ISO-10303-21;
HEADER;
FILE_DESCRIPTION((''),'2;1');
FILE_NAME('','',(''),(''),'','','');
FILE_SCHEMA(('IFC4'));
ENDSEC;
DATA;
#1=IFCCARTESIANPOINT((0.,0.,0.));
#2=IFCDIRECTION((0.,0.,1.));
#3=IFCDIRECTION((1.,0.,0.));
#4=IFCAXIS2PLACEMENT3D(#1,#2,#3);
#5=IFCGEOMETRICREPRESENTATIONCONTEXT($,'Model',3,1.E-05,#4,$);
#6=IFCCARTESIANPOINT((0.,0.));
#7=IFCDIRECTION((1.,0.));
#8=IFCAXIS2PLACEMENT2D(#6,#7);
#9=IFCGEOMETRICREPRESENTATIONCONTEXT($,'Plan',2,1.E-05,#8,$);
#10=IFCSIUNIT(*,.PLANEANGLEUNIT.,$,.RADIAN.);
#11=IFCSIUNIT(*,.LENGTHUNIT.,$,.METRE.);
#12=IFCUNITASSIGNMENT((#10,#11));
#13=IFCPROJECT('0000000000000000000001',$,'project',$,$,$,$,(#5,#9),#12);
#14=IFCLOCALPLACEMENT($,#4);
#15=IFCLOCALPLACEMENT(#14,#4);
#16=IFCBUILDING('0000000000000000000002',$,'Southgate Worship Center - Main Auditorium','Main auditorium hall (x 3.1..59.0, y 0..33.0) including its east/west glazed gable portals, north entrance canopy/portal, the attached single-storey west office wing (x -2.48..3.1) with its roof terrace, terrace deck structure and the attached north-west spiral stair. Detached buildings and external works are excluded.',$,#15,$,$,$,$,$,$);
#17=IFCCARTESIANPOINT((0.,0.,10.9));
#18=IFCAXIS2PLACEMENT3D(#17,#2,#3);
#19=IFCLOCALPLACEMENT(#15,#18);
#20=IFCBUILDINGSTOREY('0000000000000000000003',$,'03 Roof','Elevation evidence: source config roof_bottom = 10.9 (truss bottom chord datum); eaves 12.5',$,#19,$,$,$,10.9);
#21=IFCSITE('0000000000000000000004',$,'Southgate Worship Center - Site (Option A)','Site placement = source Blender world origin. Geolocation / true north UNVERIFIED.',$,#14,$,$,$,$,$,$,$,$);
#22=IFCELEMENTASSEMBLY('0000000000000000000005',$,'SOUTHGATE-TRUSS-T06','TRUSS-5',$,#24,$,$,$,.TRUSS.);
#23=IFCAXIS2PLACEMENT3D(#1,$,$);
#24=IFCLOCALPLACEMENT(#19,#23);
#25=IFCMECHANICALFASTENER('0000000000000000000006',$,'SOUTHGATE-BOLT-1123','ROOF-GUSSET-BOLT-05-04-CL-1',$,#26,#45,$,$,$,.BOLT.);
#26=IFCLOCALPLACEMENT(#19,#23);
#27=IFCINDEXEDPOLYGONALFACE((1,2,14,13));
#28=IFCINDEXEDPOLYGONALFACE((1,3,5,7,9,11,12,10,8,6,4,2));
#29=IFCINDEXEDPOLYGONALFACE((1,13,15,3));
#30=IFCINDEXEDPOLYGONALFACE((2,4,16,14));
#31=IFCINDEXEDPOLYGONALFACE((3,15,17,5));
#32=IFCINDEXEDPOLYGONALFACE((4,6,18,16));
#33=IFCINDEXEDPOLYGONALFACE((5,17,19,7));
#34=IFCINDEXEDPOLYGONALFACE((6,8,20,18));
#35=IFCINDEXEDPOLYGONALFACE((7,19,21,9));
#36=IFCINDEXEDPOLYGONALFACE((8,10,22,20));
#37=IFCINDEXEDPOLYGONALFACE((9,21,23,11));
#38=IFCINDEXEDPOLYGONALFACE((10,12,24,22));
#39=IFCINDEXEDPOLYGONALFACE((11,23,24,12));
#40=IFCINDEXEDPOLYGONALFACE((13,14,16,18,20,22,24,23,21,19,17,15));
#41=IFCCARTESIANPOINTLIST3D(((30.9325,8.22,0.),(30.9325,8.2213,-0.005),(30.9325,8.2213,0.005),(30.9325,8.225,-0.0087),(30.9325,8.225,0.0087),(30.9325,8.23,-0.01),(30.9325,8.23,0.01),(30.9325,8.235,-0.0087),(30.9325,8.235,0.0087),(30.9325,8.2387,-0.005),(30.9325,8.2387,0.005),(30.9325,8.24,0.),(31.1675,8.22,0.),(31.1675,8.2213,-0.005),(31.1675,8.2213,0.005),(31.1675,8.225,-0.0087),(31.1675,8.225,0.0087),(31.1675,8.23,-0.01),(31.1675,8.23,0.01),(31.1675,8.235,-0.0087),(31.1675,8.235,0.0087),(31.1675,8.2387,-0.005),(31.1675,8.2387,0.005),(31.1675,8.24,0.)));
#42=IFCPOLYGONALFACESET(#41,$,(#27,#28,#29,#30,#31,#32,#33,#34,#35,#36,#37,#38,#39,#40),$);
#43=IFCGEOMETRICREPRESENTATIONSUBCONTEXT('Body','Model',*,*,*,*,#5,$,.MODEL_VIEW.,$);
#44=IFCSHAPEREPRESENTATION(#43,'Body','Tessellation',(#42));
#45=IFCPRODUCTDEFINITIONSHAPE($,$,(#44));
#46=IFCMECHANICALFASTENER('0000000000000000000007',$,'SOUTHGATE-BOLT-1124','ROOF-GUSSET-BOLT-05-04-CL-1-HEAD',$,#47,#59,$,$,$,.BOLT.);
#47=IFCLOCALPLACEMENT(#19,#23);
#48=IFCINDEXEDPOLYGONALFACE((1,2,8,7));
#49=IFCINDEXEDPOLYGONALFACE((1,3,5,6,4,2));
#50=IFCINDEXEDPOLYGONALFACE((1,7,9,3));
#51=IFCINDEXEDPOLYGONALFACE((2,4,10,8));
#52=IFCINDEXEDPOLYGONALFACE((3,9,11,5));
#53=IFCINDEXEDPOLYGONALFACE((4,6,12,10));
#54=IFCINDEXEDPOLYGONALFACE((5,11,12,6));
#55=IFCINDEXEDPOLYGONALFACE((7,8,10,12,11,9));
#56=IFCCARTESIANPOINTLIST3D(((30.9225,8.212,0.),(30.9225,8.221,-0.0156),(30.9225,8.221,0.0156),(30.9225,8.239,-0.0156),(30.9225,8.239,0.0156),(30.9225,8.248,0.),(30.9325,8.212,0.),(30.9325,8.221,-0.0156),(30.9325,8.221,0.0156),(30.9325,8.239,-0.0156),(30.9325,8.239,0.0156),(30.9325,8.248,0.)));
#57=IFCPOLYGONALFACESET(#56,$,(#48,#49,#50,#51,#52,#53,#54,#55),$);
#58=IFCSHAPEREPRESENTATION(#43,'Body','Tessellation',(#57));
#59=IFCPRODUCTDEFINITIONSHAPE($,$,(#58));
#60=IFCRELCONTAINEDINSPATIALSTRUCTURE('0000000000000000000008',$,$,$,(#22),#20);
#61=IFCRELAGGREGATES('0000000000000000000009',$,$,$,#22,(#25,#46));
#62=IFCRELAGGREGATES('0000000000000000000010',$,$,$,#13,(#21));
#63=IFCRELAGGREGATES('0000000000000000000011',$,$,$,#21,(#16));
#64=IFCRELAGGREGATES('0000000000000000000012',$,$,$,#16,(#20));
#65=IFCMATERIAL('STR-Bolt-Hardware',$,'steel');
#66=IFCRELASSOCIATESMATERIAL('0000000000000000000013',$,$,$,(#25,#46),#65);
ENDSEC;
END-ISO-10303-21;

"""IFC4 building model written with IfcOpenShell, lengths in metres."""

from ifc_helpers import new_model, si_unit, frame, origin_with_axes, origin_2d_with_axis, place, context, subcontext, project, spatial, indexed_curve, outline, extrude, material, element, aggregate, save


model = new_model("IFC4")

# Units and contexts
model_context = context("Model", 3, precision=1e-05, world=origin_with_axes())
plan_context = context("Plan", 2, precision=1e-05, world=origin_2d_with_axis())
body_context = subcontext(model_context, "Body", "Model", "MODEL_VIEW")
ifc_project = project(units=[si_unit("PLANEANGLEUNIT", "RADIAN"), si_unit("LENGTHUNIT", "METRE")], contexts=[model_context, plan_context])

# Site, building, storey
site_placement = place(None, origin_with_axes())
site = spatial("IfcSite", under=ifc_project, at=site_placement, Name="Southgate Worship Center - Site (Option A)", Description="Site placement = source Blender world origin. Geolocation / true north UNVERIFIED.")
building_placement = place(site_placement, origin_with_axes())
building = spatial("IfcBuilding", under=site, at=building_placement, Name="Southgate Worship Center - Main Auditorium", Description="Main auditorium hall (x 3.1..59.0, y 0..33.0) including its east/west glazed gable portals, north entrance canopy/portal, the attached single-storey west office wing (x -2.48..3.1) with its roof terrace, terrace deck structure and the attached north-west spiral stair. Detached buildings and external works are excluded.")
storey_placement = place(building_placement, frame((0.0, 0.0, 10.9), z_axis=(0.0, 0.0, 1.0), x_axis=(1.0, 0.0, 0.0)))
storey = spatial("IfcBuildingStorey", under=building, at=storey_placement, Name="03 Roof", Description="Elevation evidence: source config roof_bottom = 10.9 (truss bottom chord datum); eaves 12.5", Elevation=10.9)

# Element assembly, mechanical fasteners
assembly_placement = place(storey_placement, origin_with_axes())
assembly = element("IfcElementAssembly", 1, at=assembly_placement, inside=storey, Name="SOUTHGATE-TRUSS-T06", Description="TRUSS-5", PredefinedType="TRUSS")
ifc_material = material(Name="STR-Bolt-Hardware", Category="steel")
mechanical_fastener_1_placement = place(assembly_placement, frame((30.9325, 8.22, -0.01), z_axis=(0.0, 0.0, 1.0), x_axis=(1.0, 0.0, 0.0)))
mechanical_fastener_1 = element("IfcMechanicalFastener", 2, at=mechanical_fastener_1_placement, material=ifc_material, Name="SOUTHGATE-BOLT-1123", Description="ROOF-GUSSET-BOLT-05-04-CL-1", PredefinedType="BOLT", context=body_context, shape_type="SweptSolid", body=[
    extrude(outline(indexed_curve([(0.0, 0.0), (0.0013, -0.005), (0.005, -0.0087), (0.01, -0.01), (0.015, -0.0087), (0.0187, -0.005), (0.02, 0.0), (0.0187, 0.005), (0.015, 0.0087), (0.01, 0.01), (0.005, 0.0087), (0.0013, 0.005), (0.0, 0.0)], self_intersect=False)), frame((0.0, 0.0, 0.01), z_axis=(1.0, 0.0, 0.0), x_axis=(0.0, 1.0, 0.0)), (0.0, 0.0, 1.0), 0.235),
])
mechanical_fastener_2_placement = place(assembly_placement, frame((30.9225, 8.212, -0.0156), z_axis=(0.0, 0.0, 1.0), x_axis=(1.0, 0.0, 0.0)))
mechanical_fastener_2 = element("IfcMechanicalFastener", 3, at=mechanical_fastener_2_placement, material=ifc_material, Name="SOUTHGATE-BOLT-1124", Description="ROOF-GUSSET-BOLT-05-04-CL-1-HEAD", PredefinedType="BOLT", context=body_context, shape_type="SweptSolid", body=[
    extrude(outline(indexed_curve([(0.0, 0.0), (0.009, -0.0156), (0.027, -0.0156), (0.036, 0.0), (0.027, 0.0156), (0.009, 0.0156), (0.0, 0.0)], self_intersect=False)), frame((0.0, 0.0, 0.0156), z_axis=(1.0, 0.0, 0.0), x_axis=(0.0, 1.0, 0.0)), (0.0, 0.0, 1.0), 0.01),
])
aggregate(assembly, [mechanical_fastener_1, mechanical_fastener_2])

save(model, "model.ifc")
